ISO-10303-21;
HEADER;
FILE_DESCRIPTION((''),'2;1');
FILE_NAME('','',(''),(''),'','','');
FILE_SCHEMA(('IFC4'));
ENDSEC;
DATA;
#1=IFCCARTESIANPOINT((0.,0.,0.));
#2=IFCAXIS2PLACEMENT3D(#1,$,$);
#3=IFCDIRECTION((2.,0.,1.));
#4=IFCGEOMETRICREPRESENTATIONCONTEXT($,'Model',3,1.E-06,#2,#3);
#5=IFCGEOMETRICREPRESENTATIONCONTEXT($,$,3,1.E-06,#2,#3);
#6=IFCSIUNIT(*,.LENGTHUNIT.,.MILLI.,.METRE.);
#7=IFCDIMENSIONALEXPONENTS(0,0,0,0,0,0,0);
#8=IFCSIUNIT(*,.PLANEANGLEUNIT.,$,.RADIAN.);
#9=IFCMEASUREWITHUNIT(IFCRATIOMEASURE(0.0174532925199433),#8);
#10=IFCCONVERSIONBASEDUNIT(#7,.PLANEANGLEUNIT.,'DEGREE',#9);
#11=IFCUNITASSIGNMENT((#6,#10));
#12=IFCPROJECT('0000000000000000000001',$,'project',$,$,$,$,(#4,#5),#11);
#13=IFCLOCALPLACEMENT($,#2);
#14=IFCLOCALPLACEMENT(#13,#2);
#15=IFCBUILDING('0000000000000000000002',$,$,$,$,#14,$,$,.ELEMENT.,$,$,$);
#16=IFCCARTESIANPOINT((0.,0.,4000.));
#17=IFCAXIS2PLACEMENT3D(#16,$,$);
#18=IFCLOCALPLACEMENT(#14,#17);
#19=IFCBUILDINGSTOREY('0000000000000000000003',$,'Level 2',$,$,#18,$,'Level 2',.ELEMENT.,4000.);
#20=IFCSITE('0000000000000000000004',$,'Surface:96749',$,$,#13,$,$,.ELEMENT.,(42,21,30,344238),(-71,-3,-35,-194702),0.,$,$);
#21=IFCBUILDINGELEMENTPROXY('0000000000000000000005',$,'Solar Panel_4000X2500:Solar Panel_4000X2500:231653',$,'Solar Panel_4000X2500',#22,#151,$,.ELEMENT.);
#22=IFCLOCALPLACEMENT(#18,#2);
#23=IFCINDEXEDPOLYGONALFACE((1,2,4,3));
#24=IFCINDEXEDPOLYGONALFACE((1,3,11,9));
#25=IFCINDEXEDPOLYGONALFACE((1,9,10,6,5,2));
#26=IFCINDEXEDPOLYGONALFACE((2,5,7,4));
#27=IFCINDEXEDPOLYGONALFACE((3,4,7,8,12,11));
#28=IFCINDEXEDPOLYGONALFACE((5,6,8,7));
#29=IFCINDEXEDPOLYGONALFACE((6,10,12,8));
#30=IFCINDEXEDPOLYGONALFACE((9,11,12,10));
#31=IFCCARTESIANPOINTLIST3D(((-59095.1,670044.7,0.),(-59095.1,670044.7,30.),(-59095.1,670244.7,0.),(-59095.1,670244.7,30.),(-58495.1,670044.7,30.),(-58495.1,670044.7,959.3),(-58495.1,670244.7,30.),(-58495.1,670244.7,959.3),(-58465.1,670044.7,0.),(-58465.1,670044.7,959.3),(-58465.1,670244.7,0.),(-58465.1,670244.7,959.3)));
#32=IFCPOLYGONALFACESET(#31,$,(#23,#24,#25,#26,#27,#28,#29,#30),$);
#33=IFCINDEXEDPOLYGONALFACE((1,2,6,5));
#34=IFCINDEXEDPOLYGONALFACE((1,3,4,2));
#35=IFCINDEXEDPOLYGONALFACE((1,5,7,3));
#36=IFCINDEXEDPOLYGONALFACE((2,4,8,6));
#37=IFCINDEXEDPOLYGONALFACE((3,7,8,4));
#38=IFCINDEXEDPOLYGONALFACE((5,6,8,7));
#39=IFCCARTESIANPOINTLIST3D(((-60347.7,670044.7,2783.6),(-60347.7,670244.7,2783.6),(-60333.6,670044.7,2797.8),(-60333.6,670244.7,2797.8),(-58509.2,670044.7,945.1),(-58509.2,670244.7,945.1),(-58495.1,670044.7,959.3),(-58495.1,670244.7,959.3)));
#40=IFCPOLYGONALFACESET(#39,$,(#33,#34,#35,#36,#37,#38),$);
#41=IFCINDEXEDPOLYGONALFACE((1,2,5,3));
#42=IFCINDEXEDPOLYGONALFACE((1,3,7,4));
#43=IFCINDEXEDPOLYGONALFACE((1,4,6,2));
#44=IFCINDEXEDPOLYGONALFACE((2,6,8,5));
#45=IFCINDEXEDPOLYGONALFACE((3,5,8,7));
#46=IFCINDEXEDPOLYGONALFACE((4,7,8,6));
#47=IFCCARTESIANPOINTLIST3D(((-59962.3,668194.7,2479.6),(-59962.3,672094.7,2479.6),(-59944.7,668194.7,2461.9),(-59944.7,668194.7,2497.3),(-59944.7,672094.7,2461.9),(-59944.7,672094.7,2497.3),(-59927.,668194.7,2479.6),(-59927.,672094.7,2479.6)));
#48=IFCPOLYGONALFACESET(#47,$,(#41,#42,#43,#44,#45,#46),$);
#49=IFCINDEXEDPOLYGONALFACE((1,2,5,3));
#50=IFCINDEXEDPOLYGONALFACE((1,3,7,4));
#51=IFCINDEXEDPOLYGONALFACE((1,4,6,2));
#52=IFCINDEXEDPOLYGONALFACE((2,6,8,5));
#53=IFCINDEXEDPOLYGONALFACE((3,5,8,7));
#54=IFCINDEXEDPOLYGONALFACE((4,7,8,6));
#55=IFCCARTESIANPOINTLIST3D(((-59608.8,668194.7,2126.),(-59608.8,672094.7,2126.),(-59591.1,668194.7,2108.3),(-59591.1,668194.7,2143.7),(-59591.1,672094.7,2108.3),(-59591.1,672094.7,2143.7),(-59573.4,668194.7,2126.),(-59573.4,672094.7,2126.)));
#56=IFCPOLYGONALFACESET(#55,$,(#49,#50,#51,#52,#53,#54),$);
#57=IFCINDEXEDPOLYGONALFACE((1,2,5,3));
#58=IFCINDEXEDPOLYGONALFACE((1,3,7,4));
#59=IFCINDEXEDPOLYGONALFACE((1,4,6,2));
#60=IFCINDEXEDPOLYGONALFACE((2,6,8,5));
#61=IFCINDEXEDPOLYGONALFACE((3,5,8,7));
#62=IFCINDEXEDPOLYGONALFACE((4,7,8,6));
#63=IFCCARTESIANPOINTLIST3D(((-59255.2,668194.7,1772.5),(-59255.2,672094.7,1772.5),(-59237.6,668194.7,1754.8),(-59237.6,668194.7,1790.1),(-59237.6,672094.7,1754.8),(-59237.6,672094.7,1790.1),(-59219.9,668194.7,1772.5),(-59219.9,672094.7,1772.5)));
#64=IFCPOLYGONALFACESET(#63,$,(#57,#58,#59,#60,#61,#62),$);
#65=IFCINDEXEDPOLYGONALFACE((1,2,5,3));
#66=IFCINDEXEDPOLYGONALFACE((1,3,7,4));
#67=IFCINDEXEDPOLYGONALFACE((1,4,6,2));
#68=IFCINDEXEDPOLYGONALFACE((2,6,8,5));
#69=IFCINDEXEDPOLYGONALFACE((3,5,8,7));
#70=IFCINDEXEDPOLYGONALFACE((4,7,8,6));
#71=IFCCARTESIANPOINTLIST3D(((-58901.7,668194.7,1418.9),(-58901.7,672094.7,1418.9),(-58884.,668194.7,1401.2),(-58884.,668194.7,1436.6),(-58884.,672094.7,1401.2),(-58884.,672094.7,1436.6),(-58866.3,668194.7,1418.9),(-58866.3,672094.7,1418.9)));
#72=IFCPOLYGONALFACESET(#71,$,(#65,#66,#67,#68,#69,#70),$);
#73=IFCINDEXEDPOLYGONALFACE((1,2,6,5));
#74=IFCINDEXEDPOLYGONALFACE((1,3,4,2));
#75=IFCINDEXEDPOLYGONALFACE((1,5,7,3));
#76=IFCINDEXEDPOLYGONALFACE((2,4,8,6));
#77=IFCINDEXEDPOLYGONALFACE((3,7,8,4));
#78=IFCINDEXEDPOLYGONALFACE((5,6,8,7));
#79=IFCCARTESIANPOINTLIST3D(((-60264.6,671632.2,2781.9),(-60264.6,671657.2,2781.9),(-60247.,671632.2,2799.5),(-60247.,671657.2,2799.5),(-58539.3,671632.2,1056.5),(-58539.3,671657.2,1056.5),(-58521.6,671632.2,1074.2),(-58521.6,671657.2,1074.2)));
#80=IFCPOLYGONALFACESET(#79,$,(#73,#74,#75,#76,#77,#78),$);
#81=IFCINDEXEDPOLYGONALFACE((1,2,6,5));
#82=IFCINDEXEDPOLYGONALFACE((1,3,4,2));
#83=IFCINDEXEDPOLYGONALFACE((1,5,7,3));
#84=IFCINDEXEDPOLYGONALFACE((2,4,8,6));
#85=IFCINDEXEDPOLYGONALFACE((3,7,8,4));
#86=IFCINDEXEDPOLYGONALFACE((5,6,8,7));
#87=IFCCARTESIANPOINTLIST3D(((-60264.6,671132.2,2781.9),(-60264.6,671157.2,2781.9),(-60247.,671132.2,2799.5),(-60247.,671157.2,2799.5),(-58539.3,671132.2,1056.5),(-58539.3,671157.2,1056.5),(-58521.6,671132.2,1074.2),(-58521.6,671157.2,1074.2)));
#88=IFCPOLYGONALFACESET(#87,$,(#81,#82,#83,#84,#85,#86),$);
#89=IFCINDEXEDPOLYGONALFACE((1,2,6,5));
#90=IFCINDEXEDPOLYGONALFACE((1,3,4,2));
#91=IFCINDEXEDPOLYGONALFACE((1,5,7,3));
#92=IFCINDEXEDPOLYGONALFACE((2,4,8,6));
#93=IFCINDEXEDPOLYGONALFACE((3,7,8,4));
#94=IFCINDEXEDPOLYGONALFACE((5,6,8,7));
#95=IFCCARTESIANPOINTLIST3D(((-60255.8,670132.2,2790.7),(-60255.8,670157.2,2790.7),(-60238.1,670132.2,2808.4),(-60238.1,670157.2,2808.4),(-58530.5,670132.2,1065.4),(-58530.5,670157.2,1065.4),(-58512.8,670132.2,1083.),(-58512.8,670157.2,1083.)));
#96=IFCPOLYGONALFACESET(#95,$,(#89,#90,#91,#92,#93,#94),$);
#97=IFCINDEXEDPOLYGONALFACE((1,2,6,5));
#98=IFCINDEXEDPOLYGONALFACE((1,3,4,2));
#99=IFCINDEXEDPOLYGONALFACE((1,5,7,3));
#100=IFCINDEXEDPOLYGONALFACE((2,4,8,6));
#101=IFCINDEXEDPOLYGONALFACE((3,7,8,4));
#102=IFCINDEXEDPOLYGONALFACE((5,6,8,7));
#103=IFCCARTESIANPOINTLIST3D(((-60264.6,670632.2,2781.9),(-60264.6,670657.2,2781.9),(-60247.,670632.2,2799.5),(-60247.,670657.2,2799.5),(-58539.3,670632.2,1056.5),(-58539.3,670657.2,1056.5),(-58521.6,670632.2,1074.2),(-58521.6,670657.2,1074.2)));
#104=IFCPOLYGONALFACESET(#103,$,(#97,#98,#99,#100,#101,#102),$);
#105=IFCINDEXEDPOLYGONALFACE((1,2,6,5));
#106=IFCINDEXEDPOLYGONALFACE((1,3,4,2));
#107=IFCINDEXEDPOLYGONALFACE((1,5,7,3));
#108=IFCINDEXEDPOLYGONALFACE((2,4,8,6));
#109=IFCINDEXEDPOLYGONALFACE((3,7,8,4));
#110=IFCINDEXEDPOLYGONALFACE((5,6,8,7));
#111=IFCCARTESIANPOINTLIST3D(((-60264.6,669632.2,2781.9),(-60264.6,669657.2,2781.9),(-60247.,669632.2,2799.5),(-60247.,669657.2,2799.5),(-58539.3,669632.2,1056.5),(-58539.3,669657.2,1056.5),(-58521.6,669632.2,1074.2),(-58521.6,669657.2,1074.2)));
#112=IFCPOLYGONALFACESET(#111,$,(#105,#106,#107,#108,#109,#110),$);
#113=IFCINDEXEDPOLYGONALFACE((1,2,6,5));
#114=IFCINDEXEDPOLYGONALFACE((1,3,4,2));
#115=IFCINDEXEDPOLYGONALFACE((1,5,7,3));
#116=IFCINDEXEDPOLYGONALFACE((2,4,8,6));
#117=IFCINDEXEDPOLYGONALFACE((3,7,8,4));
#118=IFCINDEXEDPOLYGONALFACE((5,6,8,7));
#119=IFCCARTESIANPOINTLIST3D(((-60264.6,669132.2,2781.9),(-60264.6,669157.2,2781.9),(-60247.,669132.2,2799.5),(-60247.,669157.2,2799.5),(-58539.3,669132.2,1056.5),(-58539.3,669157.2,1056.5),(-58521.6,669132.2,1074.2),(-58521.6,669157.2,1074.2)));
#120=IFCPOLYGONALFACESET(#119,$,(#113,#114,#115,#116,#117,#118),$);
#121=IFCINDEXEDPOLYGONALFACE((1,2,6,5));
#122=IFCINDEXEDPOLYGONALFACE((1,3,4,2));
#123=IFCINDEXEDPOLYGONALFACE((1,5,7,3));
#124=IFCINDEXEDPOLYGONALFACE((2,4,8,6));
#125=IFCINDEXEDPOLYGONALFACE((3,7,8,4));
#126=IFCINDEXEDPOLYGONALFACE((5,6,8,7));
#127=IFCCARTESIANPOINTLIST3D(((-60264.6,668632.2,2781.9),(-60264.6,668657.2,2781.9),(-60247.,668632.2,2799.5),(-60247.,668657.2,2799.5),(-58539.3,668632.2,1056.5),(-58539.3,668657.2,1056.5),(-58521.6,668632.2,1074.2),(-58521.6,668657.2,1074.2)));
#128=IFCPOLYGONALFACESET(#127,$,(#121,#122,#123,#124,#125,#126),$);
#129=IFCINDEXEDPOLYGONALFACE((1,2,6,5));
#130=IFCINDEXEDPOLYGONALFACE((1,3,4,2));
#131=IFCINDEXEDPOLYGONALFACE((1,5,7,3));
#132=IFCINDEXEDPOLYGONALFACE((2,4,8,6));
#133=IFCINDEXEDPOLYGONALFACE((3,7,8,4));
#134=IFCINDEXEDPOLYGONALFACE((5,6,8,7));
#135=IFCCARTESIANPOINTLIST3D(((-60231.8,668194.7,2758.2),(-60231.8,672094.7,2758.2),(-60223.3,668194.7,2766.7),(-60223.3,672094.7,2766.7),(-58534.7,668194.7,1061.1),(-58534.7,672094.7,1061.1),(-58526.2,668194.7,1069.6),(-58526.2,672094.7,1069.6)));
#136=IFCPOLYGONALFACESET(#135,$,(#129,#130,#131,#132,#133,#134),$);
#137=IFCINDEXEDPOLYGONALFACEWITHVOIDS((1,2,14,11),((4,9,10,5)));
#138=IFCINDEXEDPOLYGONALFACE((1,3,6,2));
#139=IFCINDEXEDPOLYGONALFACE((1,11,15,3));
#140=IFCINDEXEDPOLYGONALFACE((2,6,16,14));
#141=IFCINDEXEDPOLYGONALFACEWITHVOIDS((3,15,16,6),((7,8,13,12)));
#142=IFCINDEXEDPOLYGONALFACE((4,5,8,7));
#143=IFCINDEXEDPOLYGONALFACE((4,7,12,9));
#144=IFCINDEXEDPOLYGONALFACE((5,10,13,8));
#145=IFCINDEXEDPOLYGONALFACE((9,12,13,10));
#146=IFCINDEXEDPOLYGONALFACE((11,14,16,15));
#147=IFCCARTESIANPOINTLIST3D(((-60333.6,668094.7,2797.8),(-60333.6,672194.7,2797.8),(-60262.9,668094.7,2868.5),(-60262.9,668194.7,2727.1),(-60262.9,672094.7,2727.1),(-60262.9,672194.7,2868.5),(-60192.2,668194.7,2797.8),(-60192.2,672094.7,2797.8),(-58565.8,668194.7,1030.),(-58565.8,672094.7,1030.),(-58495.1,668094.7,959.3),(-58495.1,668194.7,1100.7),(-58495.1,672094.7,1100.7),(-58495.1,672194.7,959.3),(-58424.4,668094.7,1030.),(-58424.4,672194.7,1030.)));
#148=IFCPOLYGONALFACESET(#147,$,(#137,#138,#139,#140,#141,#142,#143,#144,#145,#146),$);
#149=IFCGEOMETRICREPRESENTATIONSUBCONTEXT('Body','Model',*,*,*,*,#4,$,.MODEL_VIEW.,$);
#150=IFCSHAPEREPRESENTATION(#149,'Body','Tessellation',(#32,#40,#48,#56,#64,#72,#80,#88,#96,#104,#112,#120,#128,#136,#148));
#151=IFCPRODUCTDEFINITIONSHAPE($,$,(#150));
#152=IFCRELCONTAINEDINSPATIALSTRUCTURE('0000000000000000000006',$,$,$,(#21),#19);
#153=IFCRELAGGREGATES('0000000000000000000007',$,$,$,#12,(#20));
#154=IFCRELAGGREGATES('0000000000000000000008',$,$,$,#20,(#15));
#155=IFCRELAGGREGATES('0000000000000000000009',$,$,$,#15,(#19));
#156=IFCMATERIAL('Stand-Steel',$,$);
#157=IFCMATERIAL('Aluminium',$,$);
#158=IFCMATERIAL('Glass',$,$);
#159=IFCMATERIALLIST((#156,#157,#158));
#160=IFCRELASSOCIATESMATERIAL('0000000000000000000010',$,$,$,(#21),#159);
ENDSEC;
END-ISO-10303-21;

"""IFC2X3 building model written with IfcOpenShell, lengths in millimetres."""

from ifc_helpers import new_model, entity, si_unit, converted_unit, direction, frame, frame_2d, origin, origin_2d_with_axis, place, context, subcontext, project, spatial, polyline, rectangle, outline, extrude, source, transform, mapped, material, material_list, element, save


model = new_model("IFC2X3")

# Units and contexts
model_context = context("Model", 3, precision=1e-06, world=origin(), true_north=direction((2.0, 0.0, 1.0)))
context_of_model = context(None, 3, precision=1e-06, world=origin(), true_north=direction((2.0, 0.0, 1.0)))
body_context = subcontext(model_context, "Body", "Model", "MODEL_VIEW")
ifc_project = project(units=[si_unit("LENGTHUNIT", "METRE", prefix="MILLI"), converted_unit("PLANEANGLEUNIT", "DEGREE", entity("IfcRatioMeasure", 0.0174532925199433), si_unit("PLANEANGLEUNIT", "RADIAN"), dimensions=[0, 0, 0, 0, 0, 0, 0])], contexts=[model_context, context_of_model])

# Site, building, storey
site_placement = place(None, origin())
site = spatial("IfcSite", under=ifc_project, at=site_placement, Name="Surface:96749", CompositionType="ELEMENT", RefLatitude=(42, 21, 30, 344238), RefLongitude=(-71, -3, -35, -194702), RefElevation=0.0)
building_placement = place(site_placement, origin())
building = spatial("IfcBuilding", under=site, at=building_placement, CompositionType="ELEMENT")
storey_placement = place(building_placement, frame((0.0, 0.0, 4000.0)))
storey = spatial("IfcBuildingStorey", under=building, at=storey_placement, Name="Level 2", LongName="Level 2", CompositionType="ELEMENT", Elevation=4000.0)

# Building element proxy
ifc_material_1 = material(Name="Stand-Steel")
ifc_material_2 = material(Name="Aluminium")
ifc_material_3 = material(Name="Glass")
shared_shape = source(origin(), body_context, "Body", "SweptSolid", [
    extrude(outline(polyline([(-629.5, -220.0), (329.8, -220.0), (329.8, 410.0), (299.8, 410.0), (299.8, -190.0), (-629.5, -190.0), (-629.5, -220.0)])), frame((-190.0, -100.0, 299.8), z_axis=(0.0, 1.0, 0.0), x_axis=(0.0, 0.0, -1.0)), (0.0, 0.0, 1.0), 200.0),
    extrude(rectangle(XDim=20.0, YDim=200.0, at=frame_2d((0.0, 0.0), x_axis=(0.0, 1.0))), frame((-7.1, 0.0, 922.2), z_axis=(-0.707107, 0.0, 0.707107), x_axis=(0.0, 1.0, 0.0)), (0.0, 0.0, 1.0), 2600.0),
    extrude(rectangle(XDim=25.0, YDim=25.0, at=frame_2d((0.0, 0.0), x_axis=(1.0, 0.0))), frame((-1449.6, -1950.0, 2449.6), z_axis=(0.0, 1.0, 0.0), x_axis=(-0.707107, 0.0, -0.707107)), (0.0, 0.0, 1.0), 3900.0),
    extrude(rectangle(XDim=25.0, YDim=25.0, at=origin_2d_with_axis()), frame((-1096.0, -1950.0, 2096.0), z_axis=(0.0, 1.0, 0.0), x_axis=(-0.707107, 0.0, -0.707107)), (0.0, 0.0, 1.0), 3900.0),
    extrude(rectangle(XDim=25.0, YDim=25.0, at=origin_2d_with_axis()), frame((-742.5, -1950.0, 1742.5), z_axis=(0.0, 1.0, 0.0), x_axis=(-0.707107, 0.0, -0.707107)), (0.0, 0.0, 1.0), 3900.0),
    extrude(rectangle(XDim=25.0, YDim=25.0, at=frame_2d((0.0, 0.0), x_axis=(1.0, 0.0))), frame((-388.9, -1950.0, 1388.9), z_axis=(0.0, 1.0, 0.0), x_axis=(-0.707107, 0.0, -0.707107)), (0.0, 0.0, 1.0), 3900.0),
    extrude(rectangle(XDim=25.0, YDim=25.0, at=frame_2d((0.0, 0.0), x_axis=(0.0, 1.0))), frame((-35.4, 1500.0, 1035.4), z_axis=(-0.707107, 0.0, 0.707107), x_axis=(0.0, 1.0, 0.0)), (0.0, 0.0, 1.0), 2440.0),
    extrude(rectangle(XDim=25.0, YDim=25.0, at=frame_2d((0.0, 0.0), x_axis=(0.0, 1.0))), frame((-35.4, 1000.0, 1035.4), z_axis=(-0.707107, 0.0, 0.707107), x_axis=(0.0, 1.0, 0.0)), (0.0, 0.0, 1.0), 2440.0),
    extrude(rectangle(XDim=25.0, YDim=25.0, at=frame_2d((0.0, 0.0), x_axis=(0.0, 1.0))), frame((-26.5, 0.0, 1044.2), z_axis=(-0.707107, 0.0, 0.707107), x_axis=(0.0, -1.0, 0.0)), (0.0, 0.0, 1.0), 2440.0),
    extrude(rectangle(XDim=25.0, YDim=25.0, at=frame_2d((0.0, 0.0), x_axis=(0.0, 1.0))), frame((-35.4, 500.0, 1035.4), z_axis=(-0.707107, 0.0, 0.707107), x_axis=(0.0, 1.0, 0.0)), (0.0, 0.0, 1.0), 2440.0),
    extrude(rectangle(XDim=25.0, YDim=25.0, at=frame_2d((0.0, 0.0), x_axis=(0.0, 1.0))), frame((-35.4, -500.0, 1035.4), z_axis=(-0.707107, 0.0, 0.707107), x_axis=(0.0, 1.0, 0.0)), (0.0, 0.0, 1.0), 2440.0),
    extrude(rectangle(XDim=25.0, YDim=25.0, at=frame_2d((0.0, 0.0), x_axis=(0.0, 1.0))), frame((-35.4, -1000.0, 1035.4), z_axis=(-0.707107, 0.0, 0.707107), x_axis=(0.0, 1.0, 0.0)), (0.0, 0.0, 1.0), 2440.0),
    extrude(rectangle(XDim=25.0, YDim=25.0, at=frame_2d((0.0, 0.0), x_axis=(0.0, 1.0))), frame((-35.4, -1500.0, 1035.4), z_axis=(-0.707107, 0.0, 0.707107), x_axis=(0.0, 1.0, 0.0)), (0.0, 0.0, 1.0), 2440.0),
    extrude(rectangle(XDim=2400.0, YDim=12.0, at=frame_2d((0.0, 0.0), x_axis=(1.0, 0.0))), frame((-883.9, -1950.0, 1883.9), z_axis=(0.0, 1.0, 0.0), x_axis=(0.707107, 0.0, -0.707107)), (0.0, 0.0, 1.0), 3900.0),
    extrude(outline(polyline([(-2050.0, -1300.0), (2050.0, -1300.0), (2050.0, 1300.0), (-2050.0, 1300.0), (-2050.0, -1300.0)]), holes=[polyline([(1950.0, -1200.0), (-1950.0, -1200.0), (-1950.0, 1200.0), (1950.0, 1200.0), (1950.0, -1200.0)])]), frame((-919.2, 0.0, 1848.5), z_axis=(0.707107, 0.0, 0.707107), x_axis=(0.0, 1.0, 0.0)), (0.0, 0.0, 1.0), 100.0),
])
ifc_material_list_1 = material_list([ifc_material_1, ifc_material_2, ifc_material_3])
proxy_1_placement = place(storey_placement, frame((-58495.1, 670144.7, 30.0)))
element("IfcBuildingElementProxy", 1, at=proxy_1_placement, inside=storey, material=ifc_material_list_1, Name="Solar Panel_4000X2500:Solar Panel_4000X2500:231653", ObjectType="Solar Panel_4000X2500", CompositionType="ELEMENT", context=body_context, shape_type="MappedRepresentation", body=[
    mapped(shared_shape, transform((0.0, 0.0, 0.0), scale=1.0)),
])

save(model, "model.ifc")
